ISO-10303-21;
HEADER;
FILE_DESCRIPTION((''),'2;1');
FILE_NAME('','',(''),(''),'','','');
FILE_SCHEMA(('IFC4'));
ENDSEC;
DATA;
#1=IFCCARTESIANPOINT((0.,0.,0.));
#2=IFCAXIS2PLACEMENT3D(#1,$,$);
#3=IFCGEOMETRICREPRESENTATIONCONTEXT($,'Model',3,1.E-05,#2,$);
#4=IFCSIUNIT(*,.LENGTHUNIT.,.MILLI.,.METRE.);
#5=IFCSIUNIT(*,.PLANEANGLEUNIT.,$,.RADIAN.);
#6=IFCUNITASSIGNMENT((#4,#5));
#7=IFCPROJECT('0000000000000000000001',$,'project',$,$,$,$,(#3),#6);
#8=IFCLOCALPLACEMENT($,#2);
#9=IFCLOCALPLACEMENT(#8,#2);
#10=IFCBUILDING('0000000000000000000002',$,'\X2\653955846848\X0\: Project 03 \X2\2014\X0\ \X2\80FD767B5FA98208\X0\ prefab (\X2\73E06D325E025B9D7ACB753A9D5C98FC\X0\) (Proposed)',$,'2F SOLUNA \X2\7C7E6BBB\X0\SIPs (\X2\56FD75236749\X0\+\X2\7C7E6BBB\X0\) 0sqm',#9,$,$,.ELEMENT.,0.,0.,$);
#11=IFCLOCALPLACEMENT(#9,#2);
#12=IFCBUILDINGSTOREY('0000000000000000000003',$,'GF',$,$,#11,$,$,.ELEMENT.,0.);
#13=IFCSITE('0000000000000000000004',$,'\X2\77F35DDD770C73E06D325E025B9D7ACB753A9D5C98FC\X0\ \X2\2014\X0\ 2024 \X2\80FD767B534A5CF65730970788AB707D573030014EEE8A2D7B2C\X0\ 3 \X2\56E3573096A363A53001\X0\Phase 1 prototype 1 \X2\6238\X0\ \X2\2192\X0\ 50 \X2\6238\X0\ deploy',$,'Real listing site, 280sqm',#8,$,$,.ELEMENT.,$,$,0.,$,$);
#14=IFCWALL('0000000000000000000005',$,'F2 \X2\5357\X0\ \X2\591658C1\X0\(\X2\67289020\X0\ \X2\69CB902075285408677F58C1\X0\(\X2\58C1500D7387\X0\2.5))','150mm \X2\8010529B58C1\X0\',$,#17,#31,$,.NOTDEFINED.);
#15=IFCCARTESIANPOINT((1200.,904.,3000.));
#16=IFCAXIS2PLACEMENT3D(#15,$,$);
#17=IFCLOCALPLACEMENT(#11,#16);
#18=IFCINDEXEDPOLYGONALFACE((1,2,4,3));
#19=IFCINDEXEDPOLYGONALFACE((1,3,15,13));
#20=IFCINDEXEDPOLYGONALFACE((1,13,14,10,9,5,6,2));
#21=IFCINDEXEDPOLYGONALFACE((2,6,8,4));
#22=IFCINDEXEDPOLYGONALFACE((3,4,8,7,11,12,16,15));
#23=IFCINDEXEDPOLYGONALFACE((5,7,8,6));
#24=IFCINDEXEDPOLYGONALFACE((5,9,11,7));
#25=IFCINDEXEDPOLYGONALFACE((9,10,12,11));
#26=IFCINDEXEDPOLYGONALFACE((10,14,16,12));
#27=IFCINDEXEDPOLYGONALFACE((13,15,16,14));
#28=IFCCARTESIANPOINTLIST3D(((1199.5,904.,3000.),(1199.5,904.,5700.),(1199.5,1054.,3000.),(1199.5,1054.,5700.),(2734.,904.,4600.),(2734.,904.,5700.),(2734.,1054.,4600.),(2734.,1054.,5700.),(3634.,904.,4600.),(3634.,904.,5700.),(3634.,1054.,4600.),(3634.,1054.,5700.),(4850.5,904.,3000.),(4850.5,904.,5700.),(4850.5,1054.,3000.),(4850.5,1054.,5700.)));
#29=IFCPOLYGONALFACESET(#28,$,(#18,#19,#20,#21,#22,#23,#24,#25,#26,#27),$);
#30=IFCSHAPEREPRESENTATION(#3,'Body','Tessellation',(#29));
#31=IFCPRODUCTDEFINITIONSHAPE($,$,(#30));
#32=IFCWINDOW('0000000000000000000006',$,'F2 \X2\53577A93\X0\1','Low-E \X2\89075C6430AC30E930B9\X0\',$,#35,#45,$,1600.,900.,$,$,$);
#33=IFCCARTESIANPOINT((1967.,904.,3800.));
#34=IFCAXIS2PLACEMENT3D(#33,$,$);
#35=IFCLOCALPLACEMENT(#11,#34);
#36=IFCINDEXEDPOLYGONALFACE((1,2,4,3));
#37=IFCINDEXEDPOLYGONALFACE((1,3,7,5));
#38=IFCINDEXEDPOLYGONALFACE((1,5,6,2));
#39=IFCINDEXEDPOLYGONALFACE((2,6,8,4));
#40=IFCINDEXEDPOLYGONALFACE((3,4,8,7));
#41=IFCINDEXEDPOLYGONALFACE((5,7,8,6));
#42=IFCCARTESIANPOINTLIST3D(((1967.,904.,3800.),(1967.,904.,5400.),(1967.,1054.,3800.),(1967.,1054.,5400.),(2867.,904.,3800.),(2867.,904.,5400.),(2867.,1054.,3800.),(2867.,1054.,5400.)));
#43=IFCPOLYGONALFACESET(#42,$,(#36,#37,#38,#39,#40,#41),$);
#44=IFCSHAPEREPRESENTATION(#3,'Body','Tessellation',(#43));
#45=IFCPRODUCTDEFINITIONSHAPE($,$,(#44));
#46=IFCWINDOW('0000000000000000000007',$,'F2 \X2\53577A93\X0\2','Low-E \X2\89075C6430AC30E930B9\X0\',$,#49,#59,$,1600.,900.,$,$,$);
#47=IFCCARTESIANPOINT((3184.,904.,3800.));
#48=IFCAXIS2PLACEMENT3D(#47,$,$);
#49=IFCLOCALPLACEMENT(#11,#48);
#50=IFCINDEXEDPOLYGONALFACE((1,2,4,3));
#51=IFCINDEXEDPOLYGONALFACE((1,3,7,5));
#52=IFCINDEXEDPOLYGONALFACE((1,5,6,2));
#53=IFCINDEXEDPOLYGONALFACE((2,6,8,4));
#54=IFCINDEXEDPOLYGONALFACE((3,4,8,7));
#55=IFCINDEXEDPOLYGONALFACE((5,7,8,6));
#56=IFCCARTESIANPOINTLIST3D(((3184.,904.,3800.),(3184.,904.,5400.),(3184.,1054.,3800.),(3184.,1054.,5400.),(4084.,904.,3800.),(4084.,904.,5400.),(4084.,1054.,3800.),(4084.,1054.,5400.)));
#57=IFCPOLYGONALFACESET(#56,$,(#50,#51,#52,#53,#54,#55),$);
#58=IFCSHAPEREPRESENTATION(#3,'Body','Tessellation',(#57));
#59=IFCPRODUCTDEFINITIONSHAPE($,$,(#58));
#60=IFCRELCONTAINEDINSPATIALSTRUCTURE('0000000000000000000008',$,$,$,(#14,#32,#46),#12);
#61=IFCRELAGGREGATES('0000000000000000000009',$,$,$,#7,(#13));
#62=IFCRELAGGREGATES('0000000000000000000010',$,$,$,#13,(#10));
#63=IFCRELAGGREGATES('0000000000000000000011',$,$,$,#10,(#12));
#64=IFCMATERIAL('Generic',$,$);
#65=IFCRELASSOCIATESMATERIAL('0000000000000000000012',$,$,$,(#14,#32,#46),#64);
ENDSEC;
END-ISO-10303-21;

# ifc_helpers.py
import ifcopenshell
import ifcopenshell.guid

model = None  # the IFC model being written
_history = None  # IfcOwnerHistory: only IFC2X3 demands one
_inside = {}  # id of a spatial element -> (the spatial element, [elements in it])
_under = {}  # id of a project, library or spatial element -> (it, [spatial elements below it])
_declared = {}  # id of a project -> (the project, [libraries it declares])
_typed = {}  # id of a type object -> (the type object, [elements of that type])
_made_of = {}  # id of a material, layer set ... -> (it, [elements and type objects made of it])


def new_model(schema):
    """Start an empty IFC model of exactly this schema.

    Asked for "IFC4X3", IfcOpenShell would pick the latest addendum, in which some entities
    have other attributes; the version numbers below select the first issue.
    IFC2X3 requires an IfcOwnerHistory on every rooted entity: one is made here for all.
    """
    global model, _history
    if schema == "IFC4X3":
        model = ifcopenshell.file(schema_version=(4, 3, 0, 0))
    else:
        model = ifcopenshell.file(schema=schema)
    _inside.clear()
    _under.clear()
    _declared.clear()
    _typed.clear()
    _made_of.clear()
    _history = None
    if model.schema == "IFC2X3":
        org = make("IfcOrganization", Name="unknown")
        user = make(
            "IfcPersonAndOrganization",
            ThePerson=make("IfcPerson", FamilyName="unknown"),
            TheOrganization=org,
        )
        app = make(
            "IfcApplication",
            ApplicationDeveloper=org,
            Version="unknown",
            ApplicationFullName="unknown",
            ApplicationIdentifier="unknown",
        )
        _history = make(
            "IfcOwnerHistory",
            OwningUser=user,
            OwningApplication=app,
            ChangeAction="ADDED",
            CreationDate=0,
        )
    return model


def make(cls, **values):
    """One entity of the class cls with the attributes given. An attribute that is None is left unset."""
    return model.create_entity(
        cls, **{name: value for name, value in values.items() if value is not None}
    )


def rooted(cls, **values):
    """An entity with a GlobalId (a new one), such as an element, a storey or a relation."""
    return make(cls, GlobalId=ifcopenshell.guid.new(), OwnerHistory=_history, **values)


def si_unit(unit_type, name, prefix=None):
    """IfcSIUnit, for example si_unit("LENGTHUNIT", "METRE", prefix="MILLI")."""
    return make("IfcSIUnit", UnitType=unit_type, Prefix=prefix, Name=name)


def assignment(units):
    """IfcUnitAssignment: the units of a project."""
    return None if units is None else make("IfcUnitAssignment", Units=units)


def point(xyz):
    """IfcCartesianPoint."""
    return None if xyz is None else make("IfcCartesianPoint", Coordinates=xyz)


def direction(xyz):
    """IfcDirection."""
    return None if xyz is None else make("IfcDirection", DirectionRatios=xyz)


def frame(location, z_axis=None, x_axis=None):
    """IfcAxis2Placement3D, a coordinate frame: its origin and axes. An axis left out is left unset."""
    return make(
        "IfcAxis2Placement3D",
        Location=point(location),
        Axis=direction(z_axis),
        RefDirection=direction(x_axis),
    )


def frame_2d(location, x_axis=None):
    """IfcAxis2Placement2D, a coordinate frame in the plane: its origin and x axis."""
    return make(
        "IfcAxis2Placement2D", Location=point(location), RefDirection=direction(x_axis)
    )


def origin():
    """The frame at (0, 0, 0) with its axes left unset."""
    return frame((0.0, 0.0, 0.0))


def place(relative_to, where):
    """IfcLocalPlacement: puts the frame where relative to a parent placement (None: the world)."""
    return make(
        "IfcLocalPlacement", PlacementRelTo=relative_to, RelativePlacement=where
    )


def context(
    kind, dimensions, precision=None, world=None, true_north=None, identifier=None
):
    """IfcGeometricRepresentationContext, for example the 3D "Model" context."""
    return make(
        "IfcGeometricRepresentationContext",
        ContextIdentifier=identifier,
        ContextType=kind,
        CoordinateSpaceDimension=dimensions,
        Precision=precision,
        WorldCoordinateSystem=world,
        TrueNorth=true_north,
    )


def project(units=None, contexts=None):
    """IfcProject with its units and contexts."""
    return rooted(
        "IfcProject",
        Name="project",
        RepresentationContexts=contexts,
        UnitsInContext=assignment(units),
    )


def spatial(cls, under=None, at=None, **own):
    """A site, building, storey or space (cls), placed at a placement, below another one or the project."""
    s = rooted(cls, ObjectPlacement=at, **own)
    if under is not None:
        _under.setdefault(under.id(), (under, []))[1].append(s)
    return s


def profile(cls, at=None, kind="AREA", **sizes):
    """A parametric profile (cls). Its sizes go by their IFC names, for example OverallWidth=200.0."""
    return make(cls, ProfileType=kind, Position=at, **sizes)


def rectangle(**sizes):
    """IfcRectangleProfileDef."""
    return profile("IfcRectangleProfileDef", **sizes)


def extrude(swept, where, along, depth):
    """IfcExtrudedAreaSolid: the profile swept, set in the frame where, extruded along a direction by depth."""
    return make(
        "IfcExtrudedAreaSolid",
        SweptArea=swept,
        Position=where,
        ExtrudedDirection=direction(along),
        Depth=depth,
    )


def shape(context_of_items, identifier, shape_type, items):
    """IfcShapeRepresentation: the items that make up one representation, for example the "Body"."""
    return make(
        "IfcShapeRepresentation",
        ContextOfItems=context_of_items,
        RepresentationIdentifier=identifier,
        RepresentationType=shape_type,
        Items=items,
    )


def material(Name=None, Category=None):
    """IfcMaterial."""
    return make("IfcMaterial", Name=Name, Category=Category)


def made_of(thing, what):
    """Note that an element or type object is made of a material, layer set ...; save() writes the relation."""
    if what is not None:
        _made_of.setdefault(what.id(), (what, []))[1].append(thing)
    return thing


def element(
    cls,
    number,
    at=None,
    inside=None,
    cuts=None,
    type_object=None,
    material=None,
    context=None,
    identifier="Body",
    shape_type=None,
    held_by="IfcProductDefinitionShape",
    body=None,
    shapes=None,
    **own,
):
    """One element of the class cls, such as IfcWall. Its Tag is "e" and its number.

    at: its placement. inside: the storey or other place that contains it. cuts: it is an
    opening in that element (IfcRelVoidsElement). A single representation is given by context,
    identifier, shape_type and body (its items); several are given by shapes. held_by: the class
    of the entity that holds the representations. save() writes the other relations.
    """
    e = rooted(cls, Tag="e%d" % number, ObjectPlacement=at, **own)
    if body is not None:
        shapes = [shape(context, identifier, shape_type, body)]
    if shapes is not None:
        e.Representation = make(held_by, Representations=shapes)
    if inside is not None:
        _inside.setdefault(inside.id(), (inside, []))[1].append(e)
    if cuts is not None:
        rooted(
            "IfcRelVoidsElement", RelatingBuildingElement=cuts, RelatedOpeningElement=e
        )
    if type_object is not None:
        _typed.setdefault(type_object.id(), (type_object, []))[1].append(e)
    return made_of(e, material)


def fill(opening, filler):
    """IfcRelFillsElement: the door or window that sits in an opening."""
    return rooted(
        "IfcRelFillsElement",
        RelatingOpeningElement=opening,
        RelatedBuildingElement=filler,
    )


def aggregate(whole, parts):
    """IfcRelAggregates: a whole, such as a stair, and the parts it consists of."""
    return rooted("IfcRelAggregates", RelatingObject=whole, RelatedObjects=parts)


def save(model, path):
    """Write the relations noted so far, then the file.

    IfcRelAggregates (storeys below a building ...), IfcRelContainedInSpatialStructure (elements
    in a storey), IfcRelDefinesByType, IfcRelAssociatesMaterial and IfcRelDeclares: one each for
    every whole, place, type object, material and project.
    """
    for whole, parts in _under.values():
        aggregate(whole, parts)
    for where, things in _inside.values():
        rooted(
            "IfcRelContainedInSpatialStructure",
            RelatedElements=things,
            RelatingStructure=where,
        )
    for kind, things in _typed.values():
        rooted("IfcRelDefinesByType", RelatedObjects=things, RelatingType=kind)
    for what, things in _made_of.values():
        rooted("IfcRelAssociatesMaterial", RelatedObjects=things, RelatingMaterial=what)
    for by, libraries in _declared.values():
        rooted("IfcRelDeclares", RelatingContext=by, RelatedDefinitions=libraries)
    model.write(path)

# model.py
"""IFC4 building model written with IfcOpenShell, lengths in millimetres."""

from ifc_helpers import new_model, si_unit, frame, frame_2d, origin, place, context, project, spatial, rectangle, extrude, material, element, fill, save


model = new_model("IFC4")

# Units and contexts
model_context = context("Model", 3, precision=1e-05, world=origin())
ifc_project = project(units=[si_unit("LENGTHUNIT", "METRE", prefix="MILLI"), si_unit("PLANEANGLEUNIT", "RADIAN")], contexts=[model_context])

# Site, building, storey
site_placement = place(None, origin())
site = spatial("IfcSite", under=ifc_project, at=site_placement, Name="石川県珠洲市宝立町鵜飼 — 2024 能登半島地震被災地、仮設第 3 団地隣接、Phase 1 prototype 1 戸 → 50 戸 deploy", ObjectType="Real listing site, 280sqm", CompositionType="ELEMENT", RefElevation=0.0)
building_placement = place(site_placement, origin())
building = spatial("IfcBuilding", under=site, at=building_placement, Name="改善案: Project 03 — 能登復興 prefab (珠洲市宝立町鵜飼) (Proposed)", ObjectType="2F SOLUNA 籾殻SIPs (国産杉+籾殻) 0sqm", CompositionType="ELEMENT", ElevationOfRefHeight=0.0, ElevationOfTerrain=0.0)
storey_placement = place(building_placement, origin())
storey = spatial("IfcBuildingStorey", under=building, at=storey_placement, Name="GF", CompositionType="ELEMENT", Elevation=0.0)

# Shared definitions
ifc_material_1 = material(Name="Generic")

# Wall, openings, windows
wall_1_placement = place(storey_placement, frame((1200.0, 904.0, 3000.0)))
wall_1 = element("IfcWall", 1, at=wall_1_placement, inside=storey, material=ifc_material_1, Name="F2 南 外壁(木造 構造用合板壁(壁倍率2.5))", Description="150mm 耐力壁", PredefinedType="NOTDEFINED", context=model_context, shape_type="SweptSolid", body=[
    extrude(rectangle(XDim=3651.0, YDim=150.0, at=frame_2d((1825.0, 75.0))), frame((1200.0, 904.0, 3000.0)), (0.0, 0.0, 1.0), 2700.0),
])
opening_1_placement = place(storey_placement, frame((1967.0, 904.0, 3800.0)))
opening_1 = element("IfcOpeningElement", 2, at=opening_1_placement, cuts=wall_1, PredefinedType="NOTDEFINED", context=model_context, shape_type="SweptSolid", body=[
    extrude(rectangle(XDim=900.0, YDim=150.0, at=frame_2d((450.0, 75.0))), frame((1967.0, 904.0, 3800.0)), (0.0, 0.0, 1.0), 1600.0),
])
opening_2_placement = place(storey_placement, frame((3184.0, 904.0, 3800.0)))
opening_2 = element("IfcOpeningElement", 3, at=opening_2_placement, cuts=wall_1, PredefinedType="NOTDEFINED", context=model_context, shape_type="SweptSolid", body=[
    extrude(rectangle(XDim=900.0, YDim=150.0, at=frame_2d((450.0, 75.0))), frame((3184.0, 904.0, 3800.0)), (0.0, 0.0, 1.0), 1600.0),
])
window_1_placement = place(storey_placement, frame((1967.0, 904.0, 3800.0)))
window_1 = element("IfcWindow", 4, at=window_1_placement, inside=storey, material=ifc_material_1, Name="F2 南窓1", Description="Low-E 複層ガラス", OverallHeight=1600.0, OverallWidth=900.0, context=model_context, shape_type="SweptSolid", body=[
    extrude(rectangle(XDim=900.0, YDim=150.0, at=frame_2d((450.0, 75.0))), frame((1967.0, 904.0, 3800.0)), (0.0, 0.0, 1.0), 1600.0),
])
fill(opening_1, window_1)
window_2_placement = place(storey_placement, frame((3184.0, 904.0, 3800.0)))
window_2 = element("IfcWindow", 5, at=window_2_placement, inside=storey, material=ifc_material_1, Name="F2 南窓2", Description="Low-E 複層ガラス", OverallHeight=1600.0, OverallWidth=900.0, context=model_context, shape_type="SweptSolid", body=[
    extrude(rectangle(XDim=900.0, YDim=150.0, at=frame_2d((450.0, 75.0))), frame((3184.0, 904.0, 3800.0)), (0.0, 0.0, 1.0), 1600.0),
])
fill(opening_2, window_2)

save(model, "model.ifc")
